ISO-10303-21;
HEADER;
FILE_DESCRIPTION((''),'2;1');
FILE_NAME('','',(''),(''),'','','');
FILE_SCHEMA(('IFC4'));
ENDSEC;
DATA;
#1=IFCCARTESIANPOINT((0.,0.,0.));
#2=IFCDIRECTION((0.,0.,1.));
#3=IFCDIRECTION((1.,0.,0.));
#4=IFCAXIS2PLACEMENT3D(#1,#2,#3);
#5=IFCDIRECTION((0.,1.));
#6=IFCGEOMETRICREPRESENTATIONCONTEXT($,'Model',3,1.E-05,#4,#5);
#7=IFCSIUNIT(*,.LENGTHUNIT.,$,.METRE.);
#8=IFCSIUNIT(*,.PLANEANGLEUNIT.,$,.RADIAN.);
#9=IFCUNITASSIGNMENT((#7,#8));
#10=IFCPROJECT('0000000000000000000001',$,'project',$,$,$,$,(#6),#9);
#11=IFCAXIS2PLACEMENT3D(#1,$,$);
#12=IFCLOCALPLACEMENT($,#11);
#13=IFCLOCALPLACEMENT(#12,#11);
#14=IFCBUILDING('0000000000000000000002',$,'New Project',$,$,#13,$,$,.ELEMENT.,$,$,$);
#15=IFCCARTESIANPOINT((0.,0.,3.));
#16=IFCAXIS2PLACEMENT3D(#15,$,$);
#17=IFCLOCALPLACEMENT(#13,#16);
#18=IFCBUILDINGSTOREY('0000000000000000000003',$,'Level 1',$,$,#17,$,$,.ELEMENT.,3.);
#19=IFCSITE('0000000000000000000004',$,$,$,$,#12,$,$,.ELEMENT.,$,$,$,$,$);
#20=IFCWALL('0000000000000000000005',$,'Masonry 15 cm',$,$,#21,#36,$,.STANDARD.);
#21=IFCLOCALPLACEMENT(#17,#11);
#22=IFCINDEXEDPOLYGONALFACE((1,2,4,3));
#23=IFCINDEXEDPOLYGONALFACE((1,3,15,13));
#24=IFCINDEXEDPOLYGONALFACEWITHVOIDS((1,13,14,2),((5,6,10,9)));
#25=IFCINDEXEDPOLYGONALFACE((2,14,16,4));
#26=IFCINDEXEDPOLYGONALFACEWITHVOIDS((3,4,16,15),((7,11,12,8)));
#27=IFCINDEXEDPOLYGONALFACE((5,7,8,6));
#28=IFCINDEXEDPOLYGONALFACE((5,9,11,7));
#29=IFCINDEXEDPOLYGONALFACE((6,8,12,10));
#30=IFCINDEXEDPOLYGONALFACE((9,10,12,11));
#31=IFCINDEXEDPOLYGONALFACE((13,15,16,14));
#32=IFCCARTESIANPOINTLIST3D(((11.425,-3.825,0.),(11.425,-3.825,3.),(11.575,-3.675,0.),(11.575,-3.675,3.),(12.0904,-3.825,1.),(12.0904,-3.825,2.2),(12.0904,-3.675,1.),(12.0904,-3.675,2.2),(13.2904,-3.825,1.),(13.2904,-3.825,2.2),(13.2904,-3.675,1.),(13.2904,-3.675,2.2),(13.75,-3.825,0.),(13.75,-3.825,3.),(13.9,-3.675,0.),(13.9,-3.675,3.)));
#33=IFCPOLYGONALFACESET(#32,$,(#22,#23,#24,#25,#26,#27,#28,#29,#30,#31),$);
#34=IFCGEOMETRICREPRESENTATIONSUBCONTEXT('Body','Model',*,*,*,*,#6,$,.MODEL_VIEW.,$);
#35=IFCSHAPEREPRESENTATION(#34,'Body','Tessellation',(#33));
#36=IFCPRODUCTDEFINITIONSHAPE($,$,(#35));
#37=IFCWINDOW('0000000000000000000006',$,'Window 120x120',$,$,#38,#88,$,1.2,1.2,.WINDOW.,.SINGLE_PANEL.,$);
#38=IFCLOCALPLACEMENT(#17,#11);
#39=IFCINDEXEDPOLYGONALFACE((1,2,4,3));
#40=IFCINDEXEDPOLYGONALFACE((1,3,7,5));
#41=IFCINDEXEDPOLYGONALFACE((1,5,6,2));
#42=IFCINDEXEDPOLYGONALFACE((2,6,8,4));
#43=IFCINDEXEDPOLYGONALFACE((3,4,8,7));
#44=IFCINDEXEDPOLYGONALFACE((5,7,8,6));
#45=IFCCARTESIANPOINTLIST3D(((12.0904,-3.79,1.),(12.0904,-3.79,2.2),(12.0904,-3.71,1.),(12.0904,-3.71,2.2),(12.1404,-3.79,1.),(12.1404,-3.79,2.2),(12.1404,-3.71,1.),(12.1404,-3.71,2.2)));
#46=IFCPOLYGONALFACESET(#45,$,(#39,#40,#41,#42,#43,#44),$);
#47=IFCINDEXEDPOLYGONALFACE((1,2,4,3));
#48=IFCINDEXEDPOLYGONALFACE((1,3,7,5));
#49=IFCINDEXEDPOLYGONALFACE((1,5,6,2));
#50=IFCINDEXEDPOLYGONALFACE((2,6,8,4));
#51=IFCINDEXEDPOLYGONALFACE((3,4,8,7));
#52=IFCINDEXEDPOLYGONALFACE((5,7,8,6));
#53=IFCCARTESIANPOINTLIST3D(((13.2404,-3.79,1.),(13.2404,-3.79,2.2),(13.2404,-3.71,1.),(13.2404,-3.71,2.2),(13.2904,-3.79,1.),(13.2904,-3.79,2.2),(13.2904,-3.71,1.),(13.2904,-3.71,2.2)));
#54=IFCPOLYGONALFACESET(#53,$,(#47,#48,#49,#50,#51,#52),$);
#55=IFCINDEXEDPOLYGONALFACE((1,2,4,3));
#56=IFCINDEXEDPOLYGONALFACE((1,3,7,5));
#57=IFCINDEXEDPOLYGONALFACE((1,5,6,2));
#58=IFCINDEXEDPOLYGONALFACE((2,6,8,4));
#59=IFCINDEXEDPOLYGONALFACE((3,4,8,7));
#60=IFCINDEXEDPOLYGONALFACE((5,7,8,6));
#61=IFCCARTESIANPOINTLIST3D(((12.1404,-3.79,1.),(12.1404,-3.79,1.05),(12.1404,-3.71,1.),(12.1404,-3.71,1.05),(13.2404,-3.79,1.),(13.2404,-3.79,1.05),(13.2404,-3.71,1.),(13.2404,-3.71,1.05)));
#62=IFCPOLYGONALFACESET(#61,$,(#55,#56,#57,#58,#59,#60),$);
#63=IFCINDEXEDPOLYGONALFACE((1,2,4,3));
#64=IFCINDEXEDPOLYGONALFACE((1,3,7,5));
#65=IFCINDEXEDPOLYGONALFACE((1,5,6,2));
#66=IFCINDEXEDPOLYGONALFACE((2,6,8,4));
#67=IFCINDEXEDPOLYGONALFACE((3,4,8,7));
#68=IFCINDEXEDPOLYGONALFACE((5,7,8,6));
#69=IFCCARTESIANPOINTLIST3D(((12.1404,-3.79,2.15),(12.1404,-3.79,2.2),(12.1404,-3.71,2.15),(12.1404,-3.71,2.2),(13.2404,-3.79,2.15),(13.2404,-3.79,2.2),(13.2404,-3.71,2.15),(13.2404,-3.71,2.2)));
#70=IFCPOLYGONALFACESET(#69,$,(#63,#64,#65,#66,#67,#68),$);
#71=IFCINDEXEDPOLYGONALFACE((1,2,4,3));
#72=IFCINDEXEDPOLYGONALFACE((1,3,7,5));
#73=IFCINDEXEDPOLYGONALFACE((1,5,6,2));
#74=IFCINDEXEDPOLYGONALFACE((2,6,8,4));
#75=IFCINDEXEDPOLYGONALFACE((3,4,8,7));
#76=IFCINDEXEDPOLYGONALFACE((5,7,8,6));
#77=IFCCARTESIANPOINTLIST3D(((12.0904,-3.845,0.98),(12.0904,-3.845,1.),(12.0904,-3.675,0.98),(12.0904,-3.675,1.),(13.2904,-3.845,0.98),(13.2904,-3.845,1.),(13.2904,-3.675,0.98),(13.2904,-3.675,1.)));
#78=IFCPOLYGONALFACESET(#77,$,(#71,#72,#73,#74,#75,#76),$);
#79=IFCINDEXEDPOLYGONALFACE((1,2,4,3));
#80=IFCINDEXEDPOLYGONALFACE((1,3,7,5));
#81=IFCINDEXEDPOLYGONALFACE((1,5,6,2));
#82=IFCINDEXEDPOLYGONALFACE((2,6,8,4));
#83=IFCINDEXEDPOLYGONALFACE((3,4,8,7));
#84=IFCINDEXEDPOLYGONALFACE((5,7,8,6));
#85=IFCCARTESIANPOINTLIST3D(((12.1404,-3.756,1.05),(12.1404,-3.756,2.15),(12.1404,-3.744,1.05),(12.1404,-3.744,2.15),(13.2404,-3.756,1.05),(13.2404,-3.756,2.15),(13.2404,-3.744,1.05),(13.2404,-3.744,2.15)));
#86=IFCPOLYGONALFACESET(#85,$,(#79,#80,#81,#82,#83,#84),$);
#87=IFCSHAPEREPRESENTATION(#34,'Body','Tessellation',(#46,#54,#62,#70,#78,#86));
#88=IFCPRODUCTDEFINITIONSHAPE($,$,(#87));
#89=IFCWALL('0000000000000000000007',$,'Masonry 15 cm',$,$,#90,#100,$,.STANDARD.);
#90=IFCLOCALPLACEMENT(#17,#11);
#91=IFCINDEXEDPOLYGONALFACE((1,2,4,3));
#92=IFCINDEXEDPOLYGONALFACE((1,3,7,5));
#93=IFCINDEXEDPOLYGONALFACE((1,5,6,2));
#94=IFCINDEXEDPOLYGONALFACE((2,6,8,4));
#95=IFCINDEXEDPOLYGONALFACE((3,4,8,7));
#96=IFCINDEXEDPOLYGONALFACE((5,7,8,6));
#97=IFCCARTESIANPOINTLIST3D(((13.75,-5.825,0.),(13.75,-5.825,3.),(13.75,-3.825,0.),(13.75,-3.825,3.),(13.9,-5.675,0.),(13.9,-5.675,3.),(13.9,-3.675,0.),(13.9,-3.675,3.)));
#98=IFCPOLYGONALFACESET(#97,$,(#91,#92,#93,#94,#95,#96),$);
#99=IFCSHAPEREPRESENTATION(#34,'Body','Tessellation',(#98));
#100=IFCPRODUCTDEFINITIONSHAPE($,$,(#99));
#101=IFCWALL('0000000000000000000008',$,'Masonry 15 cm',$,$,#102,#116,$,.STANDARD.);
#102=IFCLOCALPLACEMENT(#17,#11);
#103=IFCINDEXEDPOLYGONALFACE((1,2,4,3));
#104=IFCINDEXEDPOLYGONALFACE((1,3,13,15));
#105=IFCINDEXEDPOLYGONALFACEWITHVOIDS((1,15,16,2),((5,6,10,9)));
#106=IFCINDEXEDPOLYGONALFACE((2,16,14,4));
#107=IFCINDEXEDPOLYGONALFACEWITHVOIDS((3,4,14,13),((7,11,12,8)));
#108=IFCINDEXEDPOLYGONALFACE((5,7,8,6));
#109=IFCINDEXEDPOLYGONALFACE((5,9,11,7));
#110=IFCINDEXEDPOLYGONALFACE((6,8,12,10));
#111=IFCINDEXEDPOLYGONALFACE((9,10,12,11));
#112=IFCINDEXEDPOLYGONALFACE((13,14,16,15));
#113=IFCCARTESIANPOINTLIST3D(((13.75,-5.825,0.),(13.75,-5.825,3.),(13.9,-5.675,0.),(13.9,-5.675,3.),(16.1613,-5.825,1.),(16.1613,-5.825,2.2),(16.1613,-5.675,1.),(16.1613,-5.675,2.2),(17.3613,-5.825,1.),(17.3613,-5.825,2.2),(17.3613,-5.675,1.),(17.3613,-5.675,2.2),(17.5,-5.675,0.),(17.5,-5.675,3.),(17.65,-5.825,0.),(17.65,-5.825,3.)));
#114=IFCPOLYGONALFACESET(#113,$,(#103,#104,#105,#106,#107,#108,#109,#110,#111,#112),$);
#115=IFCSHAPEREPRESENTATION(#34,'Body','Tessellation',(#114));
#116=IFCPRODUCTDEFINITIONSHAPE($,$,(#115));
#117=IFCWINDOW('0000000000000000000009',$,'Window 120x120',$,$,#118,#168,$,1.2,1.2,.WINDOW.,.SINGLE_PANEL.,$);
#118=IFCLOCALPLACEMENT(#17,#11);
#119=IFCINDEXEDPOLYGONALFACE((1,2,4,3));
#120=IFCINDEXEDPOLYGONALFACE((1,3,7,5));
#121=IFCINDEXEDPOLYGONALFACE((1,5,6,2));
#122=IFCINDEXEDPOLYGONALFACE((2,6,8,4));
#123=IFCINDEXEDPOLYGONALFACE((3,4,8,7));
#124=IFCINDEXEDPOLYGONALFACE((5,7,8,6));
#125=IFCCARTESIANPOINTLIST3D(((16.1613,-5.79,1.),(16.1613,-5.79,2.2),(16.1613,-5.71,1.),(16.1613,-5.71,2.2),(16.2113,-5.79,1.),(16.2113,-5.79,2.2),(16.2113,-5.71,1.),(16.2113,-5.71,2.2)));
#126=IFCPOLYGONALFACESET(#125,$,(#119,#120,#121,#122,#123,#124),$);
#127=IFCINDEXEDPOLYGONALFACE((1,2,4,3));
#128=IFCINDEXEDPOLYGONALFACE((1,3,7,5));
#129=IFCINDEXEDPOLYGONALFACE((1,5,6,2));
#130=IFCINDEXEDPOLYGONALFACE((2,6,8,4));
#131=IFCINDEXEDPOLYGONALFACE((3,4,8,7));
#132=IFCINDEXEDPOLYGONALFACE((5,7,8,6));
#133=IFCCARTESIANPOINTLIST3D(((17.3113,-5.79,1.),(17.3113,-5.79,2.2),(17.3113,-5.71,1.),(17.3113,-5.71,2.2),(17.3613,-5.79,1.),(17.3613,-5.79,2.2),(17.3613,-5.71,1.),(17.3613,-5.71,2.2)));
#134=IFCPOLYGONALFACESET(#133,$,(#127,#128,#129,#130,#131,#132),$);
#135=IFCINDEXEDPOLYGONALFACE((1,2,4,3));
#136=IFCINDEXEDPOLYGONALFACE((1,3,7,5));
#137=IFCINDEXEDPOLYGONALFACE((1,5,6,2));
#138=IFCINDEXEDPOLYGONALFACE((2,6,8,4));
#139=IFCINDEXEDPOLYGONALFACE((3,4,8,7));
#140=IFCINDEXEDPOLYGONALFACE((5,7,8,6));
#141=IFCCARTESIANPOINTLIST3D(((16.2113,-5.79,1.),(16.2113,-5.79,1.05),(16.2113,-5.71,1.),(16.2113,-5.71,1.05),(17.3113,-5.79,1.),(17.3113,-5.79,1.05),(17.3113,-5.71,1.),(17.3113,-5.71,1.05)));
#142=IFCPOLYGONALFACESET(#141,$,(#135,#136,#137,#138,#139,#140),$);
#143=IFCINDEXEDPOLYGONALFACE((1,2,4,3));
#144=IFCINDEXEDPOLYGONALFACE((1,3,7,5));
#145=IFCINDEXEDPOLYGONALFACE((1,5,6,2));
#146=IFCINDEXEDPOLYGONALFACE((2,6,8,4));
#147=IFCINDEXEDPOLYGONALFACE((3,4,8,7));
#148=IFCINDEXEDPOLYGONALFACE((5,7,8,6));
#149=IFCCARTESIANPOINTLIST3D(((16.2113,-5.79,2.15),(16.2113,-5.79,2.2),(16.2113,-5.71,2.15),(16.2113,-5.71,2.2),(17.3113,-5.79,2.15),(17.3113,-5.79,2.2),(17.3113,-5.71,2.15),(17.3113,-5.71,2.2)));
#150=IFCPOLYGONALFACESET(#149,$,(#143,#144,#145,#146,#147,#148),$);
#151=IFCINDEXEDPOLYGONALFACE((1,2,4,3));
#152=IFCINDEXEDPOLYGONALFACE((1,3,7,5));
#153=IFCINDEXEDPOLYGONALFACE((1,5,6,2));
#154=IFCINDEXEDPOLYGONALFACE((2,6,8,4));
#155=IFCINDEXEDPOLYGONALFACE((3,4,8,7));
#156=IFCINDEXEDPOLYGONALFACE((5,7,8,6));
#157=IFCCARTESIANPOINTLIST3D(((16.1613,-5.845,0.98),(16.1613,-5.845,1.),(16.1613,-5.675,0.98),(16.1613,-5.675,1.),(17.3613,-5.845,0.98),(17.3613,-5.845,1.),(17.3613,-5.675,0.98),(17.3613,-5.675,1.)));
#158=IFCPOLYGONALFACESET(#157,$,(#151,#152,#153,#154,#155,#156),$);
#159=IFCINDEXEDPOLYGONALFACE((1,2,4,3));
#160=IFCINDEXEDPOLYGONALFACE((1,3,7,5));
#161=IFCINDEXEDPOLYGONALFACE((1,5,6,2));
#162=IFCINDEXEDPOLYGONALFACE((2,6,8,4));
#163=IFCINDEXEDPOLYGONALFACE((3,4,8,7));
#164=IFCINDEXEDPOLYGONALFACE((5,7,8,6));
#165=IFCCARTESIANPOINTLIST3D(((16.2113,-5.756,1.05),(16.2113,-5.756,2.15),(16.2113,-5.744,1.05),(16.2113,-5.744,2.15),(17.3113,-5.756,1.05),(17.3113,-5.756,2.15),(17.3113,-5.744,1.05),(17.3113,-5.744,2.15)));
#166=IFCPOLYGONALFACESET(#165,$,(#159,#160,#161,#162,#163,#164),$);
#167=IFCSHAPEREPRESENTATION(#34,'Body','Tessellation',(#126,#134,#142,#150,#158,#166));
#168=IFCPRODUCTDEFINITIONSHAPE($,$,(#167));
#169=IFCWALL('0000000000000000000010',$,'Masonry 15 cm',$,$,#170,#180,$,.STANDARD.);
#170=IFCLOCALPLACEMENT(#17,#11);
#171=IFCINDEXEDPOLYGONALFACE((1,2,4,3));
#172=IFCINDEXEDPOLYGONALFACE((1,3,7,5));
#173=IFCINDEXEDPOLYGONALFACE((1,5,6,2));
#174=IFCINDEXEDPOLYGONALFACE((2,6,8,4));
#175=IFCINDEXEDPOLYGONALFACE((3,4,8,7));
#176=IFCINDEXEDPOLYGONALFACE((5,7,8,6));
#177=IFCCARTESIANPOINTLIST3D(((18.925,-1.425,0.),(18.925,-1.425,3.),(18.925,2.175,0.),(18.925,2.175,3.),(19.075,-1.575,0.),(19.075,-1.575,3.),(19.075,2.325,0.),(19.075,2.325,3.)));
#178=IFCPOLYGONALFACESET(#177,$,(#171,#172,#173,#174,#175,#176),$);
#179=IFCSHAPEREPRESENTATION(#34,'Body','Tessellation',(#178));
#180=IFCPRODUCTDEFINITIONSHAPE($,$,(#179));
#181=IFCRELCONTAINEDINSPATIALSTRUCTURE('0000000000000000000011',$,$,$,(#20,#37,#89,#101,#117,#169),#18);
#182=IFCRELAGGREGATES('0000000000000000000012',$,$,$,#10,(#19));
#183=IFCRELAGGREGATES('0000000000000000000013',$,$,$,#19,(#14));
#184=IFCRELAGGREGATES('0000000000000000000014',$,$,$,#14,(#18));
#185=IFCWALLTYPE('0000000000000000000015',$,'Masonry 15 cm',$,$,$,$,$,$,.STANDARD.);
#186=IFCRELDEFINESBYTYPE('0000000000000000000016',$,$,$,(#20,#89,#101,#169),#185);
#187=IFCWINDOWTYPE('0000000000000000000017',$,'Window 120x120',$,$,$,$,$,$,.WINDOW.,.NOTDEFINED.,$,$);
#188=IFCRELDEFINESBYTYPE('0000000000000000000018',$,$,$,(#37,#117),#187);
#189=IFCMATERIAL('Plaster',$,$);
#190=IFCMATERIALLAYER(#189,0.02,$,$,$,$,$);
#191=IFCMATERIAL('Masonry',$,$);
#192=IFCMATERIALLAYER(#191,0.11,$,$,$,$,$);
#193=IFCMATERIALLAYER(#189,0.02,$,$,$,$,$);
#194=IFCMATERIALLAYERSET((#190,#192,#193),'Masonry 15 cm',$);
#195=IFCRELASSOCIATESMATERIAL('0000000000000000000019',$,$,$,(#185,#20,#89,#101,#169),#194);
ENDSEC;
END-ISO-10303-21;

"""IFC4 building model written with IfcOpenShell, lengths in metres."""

from ifc_helpers import new_model, si_unit, direction, frame, frame_2d, origin, origin_with_axes, place, context, subcontext, project, spatial, polyline, rectangle, outline, extrude, material, layer, layer_set, layer_usage, type_object, element, fill, save


model = new_model("IFC4")

# Units and contexts
model_context = context("Model", 3, precision=1e-05, world=origin_with_axes(), true_north=direction((0.0, 1.0)))
body_context = subcontext(model_context, "Body", "Model", "MODEL_VIEW")
ifc_project = project(units=[si_unit("LENGTHUNIT", "METRE"), si_unit("PLANEANGLEUNIT", "RADIAN")], contexts=[model_context])

# Site, building, storey
site_placement = place(None, origin())
site = spatial("IfcSite", under=ifc_project, at=site_placement, CompositionType="ELEMENT")
building_placement = place(site_placement, origin())
building = spatial("IfcBuilding", under=site, at=building_placement, Name="New Project", CompositionType="ELEMENT")
storey_placement = place(building_placement, frame((0.0, 0.0, 3.0)))
storey = spatial("IfcBuildingStorey", under=building, at=storey_placement, Name="Level 1", CompositionType="ELEMENT", Elevation=3.0)

# Shared definitions
ifc_material_1 = material(Name="Plaster")
ifc_layer_1 = layer(ifc_material_1, 0.02)
ifc_material_2 = material(Name="Masonry")
ifc_layer_2 = layer(ifc_material_2, 0.11)
ifc_layer_3 = layer(ifc_material_1, 0.02)
ifc_layer_set_1 = layer_set([ifc_layer_1, ifc_layer_2, ifc_layer_3], Name="Masonry 15 cm")
ifc_layer_usage_1 = layer_usage(ifc_layer_set_1, "AXIS2", "NEGATIVE", 0.075)
wall_type_1 = type_object("IfcWallType", Name="Masonry 15 cm", PredefinedType="STANDARD", material=ifc_layer_set_1)

# Shared definitions
window_type_1 = type_object("IfcWindowType", Name="Window 120x120", PartitioningType="NOTDEFINED", PredefinedType="WINDOW")

# Wall, opening, window
wall_1_placement = place(storey_placement, frame((13.825, -3.75, 0.0), z_axis=(0.0, 0.0, 1.0), x_axis=(-1.0, 0.0, 0.0)))
wall_1 = element("IfcWall", 1, at=wall_1_placement, inside=storey, type_object=wall_type_1, material=ifc_layer_usage_1, Name="Masonry 15 cm", PredefinedType="STANDARD", context=body_context, shape_type="SweptSolid", body=[
    extrude(outline(polyline([(-0.075, -0.075), (2.25, -0.075), (2.4, 0.075), (0.075, 0.075), (-0.075, -0.075)])), origin(), (0.0, 0.0, 1.0), 3.0),
])
opening_1_placement = place(wall_1_placement, frame((0.5346, 0.0, 1.0)))
opening_1 = element("IfcOpeningElement", 2, at=opening_1_placement, cuts=wall_1, PredefinedType="OPENING", context=body_context, shape_type="SweptSolid", body=[
    extrude(rectangle(XDim=1.2, YDim=0.25, at=frame_2d((0.6, 0.0))), origin(), (0.0, 0.0, 1.0), 1.2),
])
window_1_placement = place(opening_1_placement, origin())
window_1 = element("IfcWindow", 3, at=window_1_placement, inside=storey, type_object=window_type_1, Name="Window 120x120", OverallHeight=1.2, OverallWidth=1.2, PartitioningType="SINGLE_PANEL", PredefinedType="WINDOW", context=body_context, shape_type="SweptSolid", body=[
    extrude(outline(polyline([(1.2, 0.04), (1.15, 0.04), (1.15, -0.04), (1.2, -0.04), (1.2, 0.04)])), origin(), (0.0, 0.0, 1.0), 1.2),
    extrude(outline(polyline([(0.05, 0.04), (0.0, 0.04), (0.0, -0.04), (0.05, -0.04), (0.05, 0.04)])), origin(), (0.0, 0.0, 1.0), 1.2),
    extrude(outline(polyline([(1.15, 0.04), (0.05, 0.04), (0.05, -0.04), (1.15, -0.04), (1.15, 0.04)])), origin(), (0.0, 0.0, 1.0), 0.05),
    extrude(outline(polyline([(1.15, 0.04), (0.05, 0.04), (0.05, -0.04), (1.15, -0.04), (1.15, 0.04)])), frame((0.0, 0.0, 1.15)), (0.0, 0.0, 1.0), 0.05),
    extrude(outline(polyline([(1.2, 0.095), (0.0, 0.095), (0.0, -0.075), (1.2, -0.075), (1.2, 0.095)])), frame((0.0, 0.0, -0.02)), (0.0, 0.0, 1.0), 0.02),
    extrude(outline(polyline([(1.15, 0.006), (0.05, 0.006), (0.05, -0.006), (1.15, -0.006), (1.15, 0.006)])), frame((0.0, 0.0, 0.05)), (0.0, 0.0, 1.0), 1.1),
])
fill(opening_1, window_1)

# Wall
wall_2_placement = place(storey_placement, frame((13.825, -5.75, 0.0), z_axis=(0.0, 0.0, 1.0), x_axis=(0.0, 1.0, 0.0)))
element("IfcWall", 4, at=wall_2_placement, inside=storey, type_object=wall_type_1, material=ifc_layer_usage_1, Name="Masonry 15 cm", PredefinedType="STANDARD", context=body_context, shape_type="SweptSolid", body=[
    extrude(outline(polyline([(0.075, -0.075), (2.075, -0.075), (1.925, 0.075), (-0.075, 0.075), (0.075, -0.075)])), origin(), (0.0, 0.0, 1.0), 3.0),
])

# Wall, opening, window
wall_3_placement = place(storey_placement, frame((17.575, -5.75, 0.0), z_axis=(0.0, 0.0, 1.0), x_axis=(-1.0, 0.0, 0.0)))
wall_3 = element("IfcWall", 5, at=wall_3_placement, inside=storey, type_object=wall_type_1, material=ifc_layer_usage_1, Name="Masonry 15 cm", PredefinedType="STANDARD", context=body_context, shape_type="SweptSolid", body=[
    extrude(outline(polyline([(0.075, -0.075), (3.675, -0.075), (3.825, 0.075), (-0.075, 0.075), (0.075, -0.075)])), origin(), (0.0, 0.0, 1.0), 3.0),
])
opening_2_placement = place(wall_3_placement, frame((0.2137, 0.0, 1.0)))
opening_2 = element("IfcOpeningElement", 6, at=opening_2_placement, cuts=wall_3, PredefinedType="OPENING", context=body_context, shape_type="SweptSolid", body=[
    extrude(rectangle(XDim=1.2, YDim=0.25, at=frame_2d((0.6, 0.0))), origin(), (0.0, 0.0, 1.0), 1.2),
])
window_2_placement = place(opening_2_placement, origin())
window_2 = element("IfcWindow", 7, at=window_2_placement, inside=storey, type_object=window_type_1, Name="Window 120x120", OverallHeight=1.2, OverallWidth=1.2, PartitioningType="SINGLE_PANEL", PredefinedType="WINDOW", context=body_context, shape_type="SweptSolid", body=[
    extrude(outline(polyline([(1.2, 0.04), (1.15, 0.04), (1.15, -0.04), (1.2, -0.04), (1.2, 0.04)])), origin(), (0.0, 0.0, 1.0), 1.2),
    extrude(outline(polyline([(0.05, 0.04), (0.0, 0.04), (0.0, -0.04), (0.05, -0.04), (0.05, 0.04)])), origin(), (0.0, 0.0, 1.0), 1.2),
    extrude(outline(polyline([(1.15, 0.04), (0.05, 0.04), (0.05, -0.04), (1.15, -0.04), (1.15, 0.04)])), origin(), (0.0, 0.0, 1.0), 0.05),
    extrude(outline(polyline([(1.15, 0.04), (0.05, 0.04), (0.05, -0.04), (1.15, -0.04), (1.15, 0.04)])), frame((0.0, 0.0, 1.15)), (0.0, 0.0, 1.0), 0.05),
    extrude(outline(polyline([(1.2, 0.095), (0.0, 0.095), (0.0, -0.075), (1.2, -0.075), (1.2, 0.095)])), frame((0.0, 0.0, -0.02)), (0.0, 0.0, 1.0), 0.02),
    extrude(outline(polyline([(1.15, 0.006), (0.05, 0.006), (0.05, -0.006), (1.15, -0.006), (1.15, 0.006)])), frame((0.0, 0.0, 0.05)), (0.0, 0.0, 1.0), 1.1),
])
fill(opening_2, window_2)

# Wall
wall_4_placement = place(storey_placement, frame((19.0, 2.25, 0.0), z_axis=(0.0, 0.0, 1.0), x_axis=(0.0, -1.0, 0.0)))
element("IfcWall", 8, at=wall_4_placement, inside=storey, type_object=wall_type_1, material=ifc_layer_usage_1, Name="Masonry 15 cm", PredefinedType="STANDARD", context=body_context, shape_type="SweptSolid", body=[
    extrude(outline(polyline([(0.075, -0.075), (3.675, -0.075), (3.825, 0.075), (-0.075, 0.075), (0.075, -0.075)])), origin(), (0.0, 0.0, 1.0), 3.0),
])

save(model, "model.ifc")
